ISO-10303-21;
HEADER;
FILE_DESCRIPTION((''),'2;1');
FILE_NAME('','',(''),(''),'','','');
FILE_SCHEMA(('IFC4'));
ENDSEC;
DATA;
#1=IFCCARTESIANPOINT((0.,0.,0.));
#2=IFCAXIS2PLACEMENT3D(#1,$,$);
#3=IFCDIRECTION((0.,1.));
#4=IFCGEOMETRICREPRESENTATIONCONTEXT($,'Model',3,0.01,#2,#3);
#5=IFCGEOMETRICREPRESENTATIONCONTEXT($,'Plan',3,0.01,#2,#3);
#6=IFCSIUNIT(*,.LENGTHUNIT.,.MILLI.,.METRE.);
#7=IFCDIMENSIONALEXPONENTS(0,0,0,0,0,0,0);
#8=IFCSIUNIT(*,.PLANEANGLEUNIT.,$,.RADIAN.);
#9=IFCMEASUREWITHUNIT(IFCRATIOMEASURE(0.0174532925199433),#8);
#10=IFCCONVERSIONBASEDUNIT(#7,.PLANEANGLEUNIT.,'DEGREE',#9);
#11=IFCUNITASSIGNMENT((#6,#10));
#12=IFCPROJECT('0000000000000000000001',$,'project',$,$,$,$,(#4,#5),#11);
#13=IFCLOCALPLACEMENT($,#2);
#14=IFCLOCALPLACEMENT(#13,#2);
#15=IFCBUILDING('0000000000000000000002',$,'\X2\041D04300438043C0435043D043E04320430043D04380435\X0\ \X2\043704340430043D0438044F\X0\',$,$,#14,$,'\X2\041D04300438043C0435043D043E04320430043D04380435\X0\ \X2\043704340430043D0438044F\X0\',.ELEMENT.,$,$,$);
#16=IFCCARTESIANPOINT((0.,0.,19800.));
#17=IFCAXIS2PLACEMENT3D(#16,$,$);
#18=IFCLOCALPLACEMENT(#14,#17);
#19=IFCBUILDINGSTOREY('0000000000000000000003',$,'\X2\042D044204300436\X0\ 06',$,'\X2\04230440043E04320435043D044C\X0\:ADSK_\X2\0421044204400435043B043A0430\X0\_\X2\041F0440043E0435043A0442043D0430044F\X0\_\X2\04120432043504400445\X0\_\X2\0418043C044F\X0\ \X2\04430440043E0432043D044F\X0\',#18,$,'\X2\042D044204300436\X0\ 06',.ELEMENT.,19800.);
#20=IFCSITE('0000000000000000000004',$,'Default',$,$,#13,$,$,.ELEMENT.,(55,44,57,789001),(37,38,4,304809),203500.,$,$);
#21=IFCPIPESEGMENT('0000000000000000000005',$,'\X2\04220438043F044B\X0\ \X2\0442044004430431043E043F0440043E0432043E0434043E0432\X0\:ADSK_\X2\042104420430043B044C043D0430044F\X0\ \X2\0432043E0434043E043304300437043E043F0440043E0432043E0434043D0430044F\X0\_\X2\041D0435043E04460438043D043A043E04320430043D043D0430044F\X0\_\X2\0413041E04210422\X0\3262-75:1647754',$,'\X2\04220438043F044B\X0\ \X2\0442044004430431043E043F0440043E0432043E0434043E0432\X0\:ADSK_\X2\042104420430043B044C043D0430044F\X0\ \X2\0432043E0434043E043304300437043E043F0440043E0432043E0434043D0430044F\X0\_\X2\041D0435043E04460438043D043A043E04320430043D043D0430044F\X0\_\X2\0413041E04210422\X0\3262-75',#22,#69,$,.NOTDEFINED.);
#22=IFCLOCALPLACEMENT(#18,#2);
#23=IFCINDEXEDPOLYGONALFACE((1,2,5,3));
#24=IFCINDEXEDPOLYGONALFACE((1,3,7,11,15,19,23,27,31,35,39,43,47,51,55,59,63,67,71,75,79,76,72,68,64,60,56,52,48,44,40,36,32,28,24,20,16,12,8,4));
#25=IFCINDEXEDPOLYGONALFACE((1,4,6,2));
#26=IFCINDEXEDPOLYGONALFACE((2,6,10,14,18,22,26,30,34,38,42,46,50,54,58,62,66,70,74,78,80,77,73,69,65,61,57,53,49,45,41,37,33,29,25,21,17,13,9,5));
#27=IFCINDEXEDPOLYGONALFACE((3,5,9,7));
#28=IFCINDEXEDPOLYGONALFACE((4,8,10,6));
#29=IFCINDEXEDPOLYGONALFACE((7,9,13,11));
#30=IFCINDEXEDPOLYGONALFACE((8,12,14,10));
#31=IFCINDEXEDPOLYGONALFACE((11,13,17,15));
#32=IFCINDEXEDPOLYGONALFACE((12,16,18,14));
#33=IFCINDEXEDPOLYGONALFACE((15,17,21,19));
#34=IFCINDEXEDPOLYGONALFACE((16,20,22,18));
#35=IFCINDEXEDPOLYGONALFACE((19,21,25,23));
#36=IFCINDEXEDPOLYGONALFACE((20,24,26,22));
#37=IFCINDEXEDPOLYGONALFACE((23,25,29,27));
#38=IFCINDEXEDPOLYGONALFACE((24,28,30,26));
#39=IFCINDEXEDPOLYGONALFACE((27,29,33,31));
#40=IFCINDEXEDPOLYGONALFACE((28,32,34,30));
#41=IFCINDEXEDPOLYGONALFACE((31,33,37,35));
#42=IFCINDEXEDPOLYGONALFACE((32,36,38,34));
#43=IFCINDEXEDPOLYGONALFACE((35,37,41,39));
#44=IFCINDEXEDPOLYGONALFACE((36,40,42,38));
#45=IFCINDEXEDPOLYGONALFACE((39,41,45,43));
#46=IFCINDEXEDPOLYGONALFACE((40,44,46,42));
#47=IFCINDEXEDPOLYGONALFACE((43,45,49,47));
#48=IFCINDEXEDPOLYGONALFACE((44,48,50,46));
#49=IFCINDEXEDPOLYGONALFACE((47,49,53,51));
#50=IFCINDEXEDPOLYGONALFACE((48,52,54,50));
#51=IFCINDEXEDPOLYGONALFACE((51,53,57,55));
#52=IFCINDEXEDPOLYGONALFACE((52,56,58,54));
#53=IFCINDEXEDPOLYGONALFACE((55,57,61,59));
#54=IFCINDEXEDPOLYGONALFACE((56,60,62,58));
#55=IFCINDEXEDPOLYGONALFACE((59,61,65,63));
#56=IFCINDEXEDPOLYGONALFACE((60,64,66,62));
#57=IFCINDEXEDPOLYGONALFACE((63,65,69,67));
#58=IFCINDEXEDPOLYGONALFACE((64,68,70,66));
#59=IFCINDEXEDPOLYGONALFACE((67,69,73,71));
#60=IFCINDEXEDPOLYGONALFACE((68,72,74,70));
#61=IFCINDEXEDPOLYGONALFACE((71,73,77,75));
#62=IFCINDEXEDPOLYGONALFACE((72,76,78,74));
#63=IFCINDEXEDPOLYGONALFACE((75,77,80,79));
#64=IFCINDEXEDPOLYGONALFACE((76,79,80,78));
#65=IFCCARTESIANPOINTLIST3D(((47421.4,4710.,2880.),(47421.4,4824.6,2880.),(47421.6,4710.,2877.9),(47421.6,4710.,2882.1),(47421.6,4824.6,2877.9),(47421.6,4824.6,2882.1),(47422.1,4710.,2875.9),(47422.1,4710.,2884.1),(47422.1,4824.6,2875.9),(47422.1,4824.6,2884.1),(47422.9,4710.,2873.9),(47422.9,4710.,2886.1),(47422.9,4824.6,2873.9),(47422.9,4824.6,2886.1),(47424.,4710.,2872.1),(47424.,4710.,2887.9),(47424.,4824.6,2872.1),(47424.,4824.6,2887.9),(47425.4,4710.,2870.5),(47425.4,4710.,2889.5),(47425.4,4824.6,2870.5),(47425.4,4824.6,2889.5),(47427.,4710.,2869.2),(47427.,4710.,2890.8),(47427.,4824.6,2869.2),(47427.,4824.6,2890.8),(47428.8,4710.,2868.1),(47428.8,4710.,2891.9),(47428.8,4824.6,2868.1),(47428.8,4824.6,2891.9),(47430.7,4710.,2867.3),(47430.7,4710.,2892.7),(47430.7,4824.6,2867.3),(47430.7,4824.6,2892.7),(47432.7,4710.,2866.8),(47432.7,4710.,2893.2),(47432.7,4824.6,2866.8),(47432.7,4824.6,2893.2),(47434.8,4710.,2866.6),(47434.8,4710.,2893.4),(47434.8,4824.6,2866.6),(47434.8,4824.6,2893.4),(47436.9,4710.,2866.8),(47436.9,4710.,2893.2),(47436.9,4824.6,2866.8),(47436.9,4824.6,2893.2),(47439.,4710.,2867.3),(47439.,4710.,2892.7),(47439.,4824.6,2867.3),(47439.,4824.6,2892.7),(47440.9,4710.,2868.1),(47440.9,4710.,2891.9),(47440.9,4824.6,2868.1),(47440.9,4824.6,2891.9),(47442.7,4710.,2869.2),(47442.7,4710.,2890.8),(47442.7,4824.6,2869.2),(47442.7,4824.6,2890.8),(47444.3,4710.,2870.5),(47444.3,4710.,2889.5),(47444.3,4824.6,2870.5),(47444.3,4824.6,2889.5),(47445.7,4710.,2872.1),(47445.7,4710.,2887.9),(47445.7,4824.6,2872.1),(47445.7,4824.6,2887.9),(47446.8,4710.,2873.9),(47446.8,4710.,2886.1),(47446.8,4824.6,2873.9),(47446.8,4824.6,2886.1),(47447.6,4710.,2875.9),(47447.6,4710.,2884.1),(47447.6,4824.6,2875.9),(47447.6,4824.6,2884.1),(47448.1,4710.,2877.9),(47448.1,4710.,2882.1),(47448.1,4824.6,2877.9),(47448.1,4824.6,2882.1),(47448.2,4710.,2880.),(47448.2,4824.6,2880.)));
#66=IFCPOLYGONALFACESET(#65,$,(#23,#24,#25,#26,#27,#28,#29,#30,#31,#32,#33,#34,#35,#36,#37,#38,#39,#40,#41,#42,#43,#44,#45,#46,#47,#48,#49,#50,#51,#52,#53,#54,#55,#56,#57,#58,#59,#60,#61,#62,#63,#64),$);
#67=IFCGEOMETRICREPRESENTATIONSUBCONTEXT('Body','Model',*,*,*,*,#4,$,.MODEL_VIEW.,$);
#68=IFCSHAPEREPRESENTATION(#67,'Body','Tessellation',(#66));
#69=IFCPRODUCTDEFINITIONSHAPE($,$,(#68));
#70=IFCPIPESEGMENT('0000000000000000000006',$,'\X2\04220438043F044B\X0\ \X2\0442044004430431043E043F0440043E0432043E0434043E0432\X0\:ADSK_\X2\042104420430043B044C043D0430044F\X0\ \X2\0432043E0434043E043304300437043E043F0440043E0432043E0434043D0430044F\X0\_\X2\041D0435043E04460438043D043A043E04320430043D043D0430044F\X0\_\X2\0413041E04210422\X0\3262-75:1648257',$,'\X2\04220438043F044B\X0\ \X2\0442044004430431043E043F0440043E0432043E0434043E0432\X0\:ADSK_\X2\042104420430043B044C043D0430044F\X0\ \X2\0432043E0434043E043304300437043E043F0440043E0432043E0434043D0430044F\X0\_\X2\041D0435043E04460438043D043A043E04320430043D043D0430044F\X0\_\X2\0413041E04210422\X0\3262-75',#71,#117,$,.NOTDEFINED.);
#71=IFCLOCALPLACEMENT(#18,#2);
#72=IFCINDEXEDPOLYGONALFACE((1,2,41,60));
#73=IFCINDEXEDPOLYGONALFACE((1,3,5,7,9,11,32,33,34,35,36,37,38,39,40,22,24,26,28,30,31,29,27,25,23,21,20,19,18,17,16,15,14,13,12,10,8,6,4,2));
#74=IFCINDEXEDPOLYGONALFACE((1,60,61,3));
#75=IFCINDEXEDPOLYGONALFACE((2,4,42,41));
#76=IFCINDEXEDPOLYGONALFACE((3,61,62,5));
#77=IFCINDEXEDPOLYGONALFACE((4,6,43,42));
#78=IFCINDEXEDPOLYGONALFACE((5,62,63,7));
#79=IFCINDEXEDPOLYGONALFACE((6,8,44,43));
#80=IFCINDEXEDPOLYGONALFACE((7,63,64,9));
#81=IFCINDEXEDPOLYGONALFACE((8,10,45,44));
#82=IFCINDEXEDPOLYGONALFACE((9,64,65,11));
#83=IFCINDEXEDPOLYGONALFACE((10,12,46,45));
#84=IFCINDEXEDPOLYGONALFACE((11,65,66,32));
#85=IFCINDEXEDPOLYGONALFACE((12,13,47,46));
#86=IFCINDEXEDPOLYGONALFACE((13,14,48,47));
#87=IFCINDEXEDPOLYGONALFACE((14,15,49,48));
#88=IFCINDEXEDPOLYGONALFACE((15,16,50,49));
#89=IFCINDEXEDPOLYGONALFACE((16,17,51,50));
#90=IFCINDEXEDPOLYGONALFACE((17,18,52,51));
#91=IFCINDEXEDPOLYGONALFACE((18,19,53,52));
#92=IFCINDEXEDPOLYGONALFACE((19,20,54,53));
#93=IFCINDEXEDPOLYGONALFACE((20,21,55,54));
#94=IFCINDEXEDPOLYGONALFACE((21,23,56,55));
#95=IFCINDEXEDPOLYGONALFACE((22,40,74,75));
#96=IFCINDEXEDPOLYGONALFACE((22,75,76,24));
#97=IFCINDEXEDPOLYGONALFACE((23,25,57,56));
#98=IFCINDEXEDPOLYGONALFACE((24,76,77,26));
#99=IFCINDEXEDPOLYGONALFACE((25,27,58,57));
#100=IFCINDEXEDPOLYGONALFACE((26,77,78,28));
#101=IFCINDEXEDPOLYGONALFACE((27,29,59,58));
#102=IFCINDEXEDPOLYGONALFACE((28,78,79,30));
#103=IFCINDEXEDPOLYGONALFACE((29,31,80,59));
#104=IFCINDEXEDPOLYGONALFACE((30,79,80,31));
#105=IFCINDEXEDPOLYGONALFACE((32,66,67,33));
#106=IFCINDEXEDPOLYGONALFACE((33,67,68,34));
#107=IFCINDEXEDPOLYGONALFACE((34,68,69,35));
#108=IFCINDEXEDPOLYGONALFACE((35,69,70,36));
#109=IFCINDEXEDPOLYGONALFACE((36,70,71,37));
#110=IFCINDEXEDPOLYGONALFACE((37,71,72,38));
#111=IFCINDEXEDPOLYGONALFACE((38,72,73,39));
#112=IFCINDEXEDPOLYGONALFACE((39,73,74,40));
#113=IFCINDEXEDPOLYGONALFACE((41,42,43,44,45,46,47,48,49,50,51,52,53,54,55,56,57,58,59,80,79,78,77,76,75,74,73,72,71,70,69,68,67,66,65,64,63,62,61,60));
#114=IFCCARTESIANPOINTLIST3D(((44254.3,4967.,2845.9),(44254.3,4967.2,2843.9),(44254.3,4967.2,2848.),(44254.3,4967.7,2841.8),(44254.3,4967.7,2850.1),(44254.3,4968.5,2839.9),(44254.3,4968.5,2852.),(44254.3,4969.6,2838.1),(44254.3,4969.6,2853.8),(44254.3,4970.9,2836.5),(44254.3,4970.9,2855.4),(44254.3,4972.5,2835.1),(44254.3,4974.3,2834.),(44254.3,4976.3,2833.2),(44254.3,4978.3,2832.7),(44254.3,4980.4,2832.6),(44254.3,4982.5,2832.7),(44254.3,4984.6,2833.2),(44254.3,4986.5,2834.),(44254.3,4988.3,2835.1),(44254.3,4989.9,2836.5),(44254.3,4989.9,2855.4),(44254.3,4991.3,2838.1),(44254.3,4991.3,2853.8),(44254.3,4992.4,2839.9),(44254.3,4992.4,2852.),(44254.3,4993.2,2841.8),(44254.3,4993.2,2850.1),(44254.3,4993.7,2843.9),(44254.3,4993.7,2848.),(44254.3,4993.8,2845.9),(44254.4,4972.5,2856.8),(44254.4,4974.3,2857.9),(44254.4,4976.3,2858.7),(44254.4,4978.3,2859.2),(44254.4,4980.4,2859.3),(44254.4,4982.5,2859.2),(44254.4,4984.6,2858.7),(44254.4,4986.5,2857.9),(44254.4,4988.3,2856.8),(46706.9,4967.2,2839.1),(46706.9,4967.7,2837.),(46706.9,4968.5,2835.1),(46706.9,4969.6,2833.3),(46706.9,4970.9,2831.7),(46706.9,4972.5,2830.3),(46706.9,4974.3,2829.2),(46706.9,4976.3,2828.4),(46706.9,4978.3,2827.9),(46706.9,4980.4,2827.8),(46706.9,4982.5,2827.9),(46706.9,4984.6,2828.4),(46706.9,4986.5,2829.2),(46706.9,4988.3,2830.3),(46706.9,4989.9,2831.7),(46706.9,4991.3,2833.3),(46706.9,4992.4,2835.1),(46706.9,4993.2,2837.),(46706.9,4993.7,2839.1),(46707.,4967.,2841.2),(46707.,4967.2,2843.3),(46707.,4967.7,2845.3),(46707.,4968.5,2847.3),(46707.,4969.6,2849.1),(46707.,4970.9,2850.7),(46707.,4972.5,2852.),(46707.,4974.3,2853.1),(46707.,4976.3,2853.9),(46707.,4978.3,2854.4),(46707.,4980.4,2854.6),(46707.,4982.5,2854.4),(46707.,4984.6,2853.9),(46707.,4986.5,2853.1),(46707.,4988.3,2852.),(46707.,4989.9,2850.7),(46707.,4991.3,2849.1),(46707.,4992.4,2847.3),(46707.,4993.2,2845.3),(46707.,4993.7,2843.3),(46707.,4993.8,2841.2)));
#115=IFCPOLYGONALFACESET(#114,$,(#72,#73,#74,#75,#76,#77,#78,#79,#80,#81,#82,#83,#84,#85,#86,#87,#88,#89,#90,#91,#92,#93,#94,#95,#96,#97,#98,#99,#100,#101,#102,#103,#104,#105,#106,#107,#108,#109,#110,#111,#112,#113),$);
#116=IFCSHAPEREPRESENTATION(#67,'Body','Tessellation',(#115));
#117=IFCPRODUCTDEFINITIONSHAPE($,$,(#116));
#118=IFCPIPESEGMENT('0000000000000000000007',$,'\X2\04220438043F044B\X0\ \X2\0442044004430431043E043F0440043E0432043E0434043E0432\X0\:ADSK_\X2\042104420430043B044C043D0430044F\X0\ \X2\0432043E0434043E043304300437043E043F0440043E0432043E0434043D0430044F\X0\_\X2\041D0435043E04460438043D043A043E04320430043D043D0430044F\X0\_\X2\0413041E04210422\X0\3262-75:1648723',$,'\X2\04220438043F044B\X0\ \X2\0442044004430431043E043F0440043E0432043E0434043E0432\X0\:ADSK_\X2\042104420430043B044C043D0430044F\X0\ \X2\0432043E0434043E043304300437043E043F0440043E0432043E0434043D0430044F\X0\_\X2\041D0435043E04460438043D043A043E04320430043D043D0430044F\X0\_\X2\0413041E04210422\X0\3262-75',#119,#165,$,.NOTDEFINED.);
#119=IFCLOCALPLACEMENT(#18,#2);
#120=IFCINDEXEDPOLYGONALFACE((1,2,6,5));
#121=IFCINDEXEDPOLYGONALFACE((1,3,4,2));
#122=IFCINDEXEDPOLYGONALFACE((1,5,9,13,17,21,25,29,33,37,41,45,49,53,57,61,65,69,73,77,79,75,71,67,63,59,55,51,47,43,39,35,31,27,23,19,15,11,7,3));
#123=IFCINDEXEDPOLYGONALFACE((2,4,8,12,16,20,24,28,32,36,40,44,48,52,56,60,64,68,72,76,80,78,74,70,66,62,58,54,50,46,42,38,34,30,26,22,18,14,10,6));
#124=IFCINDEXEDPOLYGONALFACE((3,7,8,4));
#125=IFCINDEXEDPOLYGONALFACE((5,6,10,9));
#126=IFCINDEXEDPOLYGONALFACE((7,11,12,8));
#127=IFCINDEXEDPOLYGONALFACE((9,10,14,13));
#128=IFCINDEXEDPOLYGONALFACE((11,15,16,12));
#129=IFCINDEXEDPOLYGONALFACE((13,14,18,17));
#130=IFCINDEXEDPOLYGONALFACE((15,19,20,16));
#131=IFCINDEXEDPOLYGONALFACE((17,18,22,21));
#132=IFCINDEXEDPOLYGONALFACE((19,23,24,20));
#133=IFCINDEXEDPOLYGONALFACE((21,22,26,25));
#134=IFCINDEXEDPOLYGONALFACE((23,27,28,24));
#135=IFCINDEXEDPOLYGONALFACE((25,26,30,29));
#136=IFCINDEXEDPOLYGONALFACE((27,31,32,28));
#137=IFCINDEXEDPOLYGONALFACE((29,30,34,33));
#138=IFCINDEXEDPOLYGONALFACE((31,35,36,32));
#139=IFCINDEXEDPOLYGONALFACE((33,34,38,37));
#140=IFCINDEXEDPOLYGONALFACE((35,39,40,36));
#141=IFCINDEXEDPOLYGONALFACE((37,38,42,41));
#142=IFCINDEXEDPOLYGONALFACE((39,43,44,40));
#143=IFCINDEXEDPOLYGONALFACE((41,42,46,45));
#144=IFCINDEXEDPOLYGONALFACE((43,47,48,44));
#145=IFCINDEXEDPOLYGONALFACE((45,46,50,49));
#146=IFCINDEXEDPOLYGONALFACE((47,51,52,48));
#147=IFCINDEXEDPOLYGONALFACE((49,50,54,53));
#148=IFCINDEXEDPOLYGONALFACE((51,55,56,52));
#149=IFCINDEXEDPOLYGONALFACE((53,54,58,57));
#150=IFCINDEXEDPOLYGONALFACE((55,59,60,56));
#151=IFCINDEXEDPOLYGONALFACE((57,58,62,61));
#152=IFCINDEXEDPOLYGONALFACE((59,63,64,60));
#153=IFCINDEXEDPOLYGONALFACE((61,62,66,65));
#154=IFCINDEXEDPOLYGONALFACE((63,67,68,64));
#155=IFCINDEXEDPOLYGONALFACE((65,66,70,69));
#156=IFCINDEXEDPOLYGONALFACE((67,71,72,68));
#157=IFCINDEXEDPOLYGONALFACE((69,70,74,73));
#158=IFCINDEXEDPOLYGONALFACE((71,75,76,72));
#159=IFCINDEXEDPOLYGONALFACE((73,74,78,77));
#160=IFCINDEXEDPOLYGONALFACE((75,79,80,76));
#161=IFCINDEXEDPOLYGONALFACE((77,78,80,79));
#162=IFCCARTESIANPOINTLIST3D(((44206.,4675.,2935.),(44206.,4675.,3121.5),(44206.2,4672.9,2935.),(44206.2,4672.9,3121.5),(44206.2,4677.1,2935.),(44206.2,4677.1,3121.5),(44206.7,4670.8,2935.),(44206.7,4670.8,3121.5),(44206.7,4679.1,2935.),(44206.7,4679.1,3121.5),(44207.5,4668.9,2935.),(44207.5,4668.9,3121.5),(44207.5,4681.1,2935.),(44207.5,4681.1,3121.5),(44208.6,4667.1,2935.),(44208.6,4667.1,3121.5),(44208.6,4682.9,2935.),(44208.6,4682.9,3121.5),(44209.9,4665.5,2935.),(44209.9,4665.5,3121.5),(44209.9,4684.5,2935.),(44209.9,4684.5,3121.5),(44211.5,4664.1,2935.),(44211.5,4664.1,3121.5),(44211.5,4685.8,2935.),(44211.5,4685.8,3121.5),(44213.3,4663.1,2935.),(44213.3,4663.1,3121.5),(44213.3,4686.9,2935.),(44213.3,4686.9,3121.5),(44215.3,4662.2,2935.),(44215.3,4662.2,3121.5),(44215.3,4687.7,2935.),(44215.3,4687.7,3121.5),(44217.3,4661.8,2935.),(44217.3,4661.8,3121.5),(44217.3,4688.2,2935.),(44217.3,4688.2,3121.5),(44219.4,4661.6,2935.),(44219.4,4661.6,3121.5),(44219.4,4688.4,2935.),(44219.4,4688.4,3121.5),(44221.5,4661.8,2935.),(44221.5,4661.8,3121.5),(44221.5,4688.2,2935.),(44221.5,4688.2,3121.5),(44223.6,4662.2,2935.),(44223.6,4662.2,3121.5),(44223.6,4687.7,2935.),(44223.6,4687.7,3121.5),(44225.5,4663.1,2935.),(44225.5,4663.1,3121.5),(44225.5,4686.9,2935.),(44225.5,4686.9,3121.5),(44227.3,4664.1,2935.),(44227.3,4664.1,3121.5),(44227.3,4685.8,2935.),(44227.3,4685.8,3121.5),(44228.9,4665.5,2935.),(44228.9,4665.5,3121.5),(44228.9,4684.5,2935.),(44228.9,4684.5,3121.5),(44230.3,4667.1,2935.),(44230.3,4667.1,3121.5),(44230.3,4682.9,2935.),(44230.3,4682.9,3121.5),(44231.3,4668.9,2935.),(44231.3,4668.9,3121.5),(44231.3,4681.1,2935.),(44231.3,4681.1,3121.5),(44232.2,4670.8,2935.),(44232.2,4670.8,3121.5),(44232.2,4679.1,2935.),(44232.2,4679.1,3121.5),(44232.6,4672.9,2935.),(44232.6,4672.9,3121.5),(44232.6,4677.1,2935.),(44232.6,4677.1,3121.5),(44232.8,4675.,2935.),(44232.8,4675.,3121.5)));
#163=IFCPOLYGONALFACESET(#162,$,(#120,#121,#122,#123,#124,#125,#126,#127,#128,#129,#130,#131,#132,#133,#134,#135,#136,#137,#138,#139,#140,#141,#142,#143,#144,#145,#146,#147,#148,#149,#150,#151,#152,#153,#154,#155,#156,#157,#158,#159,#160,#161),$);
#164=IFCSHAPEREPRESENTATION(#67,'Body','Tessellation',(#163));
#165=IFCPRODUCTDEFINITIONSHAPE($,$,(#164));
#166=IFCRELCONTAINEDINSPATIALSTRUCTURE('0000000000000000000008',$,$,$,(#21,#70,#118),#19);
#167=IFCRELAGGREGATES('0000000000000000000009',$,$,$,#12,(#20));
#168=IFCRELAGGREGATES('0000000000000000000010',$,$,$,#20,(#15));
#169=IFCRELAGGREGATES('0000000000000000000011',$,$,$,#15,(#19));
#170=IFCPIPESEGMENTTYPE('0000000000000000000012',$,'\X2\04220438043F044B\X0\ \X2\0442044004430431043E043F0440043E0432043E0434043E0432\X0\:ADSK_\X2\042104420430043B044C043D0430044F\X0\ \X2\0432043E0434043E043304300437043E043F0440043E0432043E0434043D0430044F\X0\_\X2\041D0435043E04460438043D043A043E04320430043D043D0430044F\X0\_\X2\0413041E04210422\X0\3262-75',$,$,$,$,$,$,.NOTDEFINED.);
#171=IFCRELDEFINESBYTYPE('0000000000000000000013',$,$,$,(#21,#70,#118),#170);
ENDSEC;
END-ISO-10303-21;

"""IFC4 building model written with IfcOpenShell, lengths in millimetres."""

from ifc_helpers import new_model, entity, si_unit, converted_unit, direction, frame, origin, place, context, subcontext, project, spatial, indexed_curve, outline, extrude, type_object, element, save


model = new_model("IFC4")

# Units and contexts
model_context = context("Model", 3, precision=0.01, world=origin(), true_north=direction((0.0, 1.0)))
plan_context = context("Plan", 3, precision=0.01, world=origin(), true_north=direction((0.0, 1.0)))
body_context = subcontext(model_context, "Body", "Model", "MODEL_VIEW")
ifc_project = project(units=[si_unit("LENGTHUNIT", "METRE", prefix="MILLI"), converted_unit("PLANEANGLEUNIT", "DEGREE", entity("IfcRatioMeasure", 0.0174532925199433), si_unit("PLANEANGLEUNIT", "RADIAN"), dimensions=[0, 0, 0, 0, 0, 0, 0])], contexts=[model_context, plan_context])

# Site, building, storey
site_placement = place(None, origin())
site = spatial("IfcSite", under=ifc_project, at=site_placement, Name="Default", CompositionType="ELEMENT", RefLatitude=(55, 44, 57, 789001), RefLongitude=(37, 38, 4, 304809), RefElevation=203500.0)
building_placement = place(site_placement, origin())
building = spatial("IfcBuilding", under=site, at=building_placement, Name="Наименование здания", LongName="Наименование здания", CompositionType="ELEMENT")
storey_placement = place(building_placement, frame((0.0, 0.0, 19800.0)))
storey = spatial("IfcBuildingStorey", under=building, at=storey_placement, Name="Этаж 06", ObjectType="Уровень:ADSK_Стрелка_Проектная_Вверх_Имя уровня", LongName="Этаж 06", CompositionType="ELEMENT", Elevation=19800.0)

# Pipe segments
pipe_segment_type = type_object("IfcPipeSegmentType", Name="Типы трубопроводов:ADSK_Стальная водогазопроводная_Неоцинкованная_ГОСТ3262-75", PredefinedType="NOTDEFINED")
placement = place(storey_placement, origin())
element("IfcPipeSegment", 1, at=placement, inside=storey, type_object=pipe_segment_type, Name="Типы трубопроводов:ADSK_Стальная водогазопроводная_Неоцинкованная_ГОСТ3262-75:1647754", ObjectType="Типы трубопроводов:ADSK_Стальная водогазопроводная_Неоцинкованная_ГОСТ3262-75", PredefinedType="NOTDEFINED", context=body_context, shape_type="SweptSolid", body=[
    extrude(outline(indexed_curve([(13.4, 0.0), (13.2, 2.1), (12.7, 4.1), (11.9, 6.1), (10.8, 7.9), (9.5, 9.5), (7.9, 10.8), (6.1, 11.9), (4.1, 12.7), (2.1, 13.2), (0.0, 13.4), (-2.1, 13.2), (-4.1, 12.7), (-6.1, 11.9), (-7.9, 10.8), (-9.5, 9.5), (-10.8, 7.9), (-11.9, 6.1), (-12.7, 4.1), (-13.2, 2.1), (-13.4, 0.0), (-13.2, -2.1), (-12.7, -4.1), (-11.9, -6.1), (-10.8, -7.9), (-9.5, -9.5), (-7.9, -10.8), (-6.1, -11.9), (-4.1, -12.7), (-2.1, -13.2), (0.0, -13.4), (2.1, -13.2), (4.1, -12.7), (6.1, -11.9), (7.9, -10.8), (9.5, -9.5), (10.8, -7.9), (11.9, -6.1), (12.7, -4.1), (13.2, -2.1), (13.4, 0.0)], self_intersect=False)), frame((47434.8, 4710.0, 2880.0), z_axis=(0.0, 1.0, 0.0), x_axis=(1.0, 0.0, 0.0)), (0.0, 0.0, 1.0), 114.6),
])
element("IfcPipeSegment", 2, at=placement, inside=storey, type_object=pipe_segment_type, Name="Типы трубопроводов:ADSK_Стальная водогазопроводная_Неоцинкованная_ГОСТ3262-75:1648257", ObjectType="Типы трубопроводов:ADSK_Стальная водогазопроводная_Неоцинкованная_ГОСТ3262-75", PredefinedType="NOTDEFINED", context=body_context, shape_type="SweptSolid", body=[
    extrude(outline(indexed_curve([(13.4, 0.0), (13.2, 2.1), (12.7, 4.1), (11.9, 6.1), (10.8, 7.9), (9.5, 9.5), (7.9, 10.8), (6.1, 11.9), (4.1, 12.7), (2.1, 13.2), (0.0, 13.4), (-2.1, 13.2), (-4.1, 12.7), (-6.1, 11.9), (-7.9, 10.8), (-9.5, 9.5), (-10.8, 7.9), (-11.9, 6.1), (-12.7, 4.1), (-13.2, 2.1), (-13.4, 0.0), (-13.2, -2.1), (-12.7, -4.1), (-11.9, -6.1), (-10.8, -7.9), (-9.5, -9.5), (-7.9, -10.8), (-6.1, -11.9), (-4.1, -12.7), (-2.1, -13.2), (0.0, -13.4), (2.1, -13.2), (4.1, -12.7), (6.1, -11.9), (7.9, -10.8), (9.5, -9.5), (10.8, -7.9), (11.9, -6.1), (12.7, -4.1), (13.2, -2.1), (13.4, 0.0)], self_intersect=False)), frame((44254.3, 4980.4, 2845.9), z_axis=(0.999998, 0.0, -0.001944), x_axis=(0.0, 1.0, 0.0)), (0.0, 0.0, 1.0), 2452.6),
])
element("IfcPipeSegment", 3, at=placement, inside=storey, type_object=pipe_segment_type, Name="Типы трубопроводов:ADSK_Стальная водогазопроводная_Неоцинкованная_ГОСТ3262-75:1648723", ObjectType="Типы трубопроводов:ADSK_Стальная водогазопроводная_Неоцинкованная_ГОСТ3262-75", PredefinedType="NOTDEFINED", context=body_context, shape_type="SweptSolid", body=[
    extrude(outline(indexed_curve([(13.4, 0.0), (13.2, 2.1), (12.7, 4.1), (11.9, 6.1), (10.8, 7.9), (9.5, 9.5), (7.9, 10.8), (6.1, 11.9), (4.1, 12.7), (2.1, 13.2), (0.0, 13.4), (-2.1, 13.2), (-4.1, 12.7), (-6.1, 11.9), (-7.9, 10.8), (-9.5, 9.5), (-10.8, 7.9), (-11.9, 6.1), (-12.7, 4.1), (-13.2, 2.1), (-13.4, 0.0), (-13.2, -2.1), (-12.7, -4.1), (-11.9, -6.1), (-10.8, -7.9), (-9.5, -9.5), (-7.9, -10.8), (-6.1, -11.9), (-4.1, -12.7), (-2.1, -13.2), (0.0, -13.4), (2.1, -13.2), (4.1, -12.7), (6.1, -11.9), (7.9, -10.8), (9.5, -9.5), (10.8, -7.9), (11.9, -6.1), (12.7, -4.1), (13.2, -2.1), (13.4, 0.0)], self_intersect=False)), frame((44219.4, 4675.0, 2935.0)), (0.0, 0.0, 1.0), 186.5),
])

save(model, "model.ifc")
